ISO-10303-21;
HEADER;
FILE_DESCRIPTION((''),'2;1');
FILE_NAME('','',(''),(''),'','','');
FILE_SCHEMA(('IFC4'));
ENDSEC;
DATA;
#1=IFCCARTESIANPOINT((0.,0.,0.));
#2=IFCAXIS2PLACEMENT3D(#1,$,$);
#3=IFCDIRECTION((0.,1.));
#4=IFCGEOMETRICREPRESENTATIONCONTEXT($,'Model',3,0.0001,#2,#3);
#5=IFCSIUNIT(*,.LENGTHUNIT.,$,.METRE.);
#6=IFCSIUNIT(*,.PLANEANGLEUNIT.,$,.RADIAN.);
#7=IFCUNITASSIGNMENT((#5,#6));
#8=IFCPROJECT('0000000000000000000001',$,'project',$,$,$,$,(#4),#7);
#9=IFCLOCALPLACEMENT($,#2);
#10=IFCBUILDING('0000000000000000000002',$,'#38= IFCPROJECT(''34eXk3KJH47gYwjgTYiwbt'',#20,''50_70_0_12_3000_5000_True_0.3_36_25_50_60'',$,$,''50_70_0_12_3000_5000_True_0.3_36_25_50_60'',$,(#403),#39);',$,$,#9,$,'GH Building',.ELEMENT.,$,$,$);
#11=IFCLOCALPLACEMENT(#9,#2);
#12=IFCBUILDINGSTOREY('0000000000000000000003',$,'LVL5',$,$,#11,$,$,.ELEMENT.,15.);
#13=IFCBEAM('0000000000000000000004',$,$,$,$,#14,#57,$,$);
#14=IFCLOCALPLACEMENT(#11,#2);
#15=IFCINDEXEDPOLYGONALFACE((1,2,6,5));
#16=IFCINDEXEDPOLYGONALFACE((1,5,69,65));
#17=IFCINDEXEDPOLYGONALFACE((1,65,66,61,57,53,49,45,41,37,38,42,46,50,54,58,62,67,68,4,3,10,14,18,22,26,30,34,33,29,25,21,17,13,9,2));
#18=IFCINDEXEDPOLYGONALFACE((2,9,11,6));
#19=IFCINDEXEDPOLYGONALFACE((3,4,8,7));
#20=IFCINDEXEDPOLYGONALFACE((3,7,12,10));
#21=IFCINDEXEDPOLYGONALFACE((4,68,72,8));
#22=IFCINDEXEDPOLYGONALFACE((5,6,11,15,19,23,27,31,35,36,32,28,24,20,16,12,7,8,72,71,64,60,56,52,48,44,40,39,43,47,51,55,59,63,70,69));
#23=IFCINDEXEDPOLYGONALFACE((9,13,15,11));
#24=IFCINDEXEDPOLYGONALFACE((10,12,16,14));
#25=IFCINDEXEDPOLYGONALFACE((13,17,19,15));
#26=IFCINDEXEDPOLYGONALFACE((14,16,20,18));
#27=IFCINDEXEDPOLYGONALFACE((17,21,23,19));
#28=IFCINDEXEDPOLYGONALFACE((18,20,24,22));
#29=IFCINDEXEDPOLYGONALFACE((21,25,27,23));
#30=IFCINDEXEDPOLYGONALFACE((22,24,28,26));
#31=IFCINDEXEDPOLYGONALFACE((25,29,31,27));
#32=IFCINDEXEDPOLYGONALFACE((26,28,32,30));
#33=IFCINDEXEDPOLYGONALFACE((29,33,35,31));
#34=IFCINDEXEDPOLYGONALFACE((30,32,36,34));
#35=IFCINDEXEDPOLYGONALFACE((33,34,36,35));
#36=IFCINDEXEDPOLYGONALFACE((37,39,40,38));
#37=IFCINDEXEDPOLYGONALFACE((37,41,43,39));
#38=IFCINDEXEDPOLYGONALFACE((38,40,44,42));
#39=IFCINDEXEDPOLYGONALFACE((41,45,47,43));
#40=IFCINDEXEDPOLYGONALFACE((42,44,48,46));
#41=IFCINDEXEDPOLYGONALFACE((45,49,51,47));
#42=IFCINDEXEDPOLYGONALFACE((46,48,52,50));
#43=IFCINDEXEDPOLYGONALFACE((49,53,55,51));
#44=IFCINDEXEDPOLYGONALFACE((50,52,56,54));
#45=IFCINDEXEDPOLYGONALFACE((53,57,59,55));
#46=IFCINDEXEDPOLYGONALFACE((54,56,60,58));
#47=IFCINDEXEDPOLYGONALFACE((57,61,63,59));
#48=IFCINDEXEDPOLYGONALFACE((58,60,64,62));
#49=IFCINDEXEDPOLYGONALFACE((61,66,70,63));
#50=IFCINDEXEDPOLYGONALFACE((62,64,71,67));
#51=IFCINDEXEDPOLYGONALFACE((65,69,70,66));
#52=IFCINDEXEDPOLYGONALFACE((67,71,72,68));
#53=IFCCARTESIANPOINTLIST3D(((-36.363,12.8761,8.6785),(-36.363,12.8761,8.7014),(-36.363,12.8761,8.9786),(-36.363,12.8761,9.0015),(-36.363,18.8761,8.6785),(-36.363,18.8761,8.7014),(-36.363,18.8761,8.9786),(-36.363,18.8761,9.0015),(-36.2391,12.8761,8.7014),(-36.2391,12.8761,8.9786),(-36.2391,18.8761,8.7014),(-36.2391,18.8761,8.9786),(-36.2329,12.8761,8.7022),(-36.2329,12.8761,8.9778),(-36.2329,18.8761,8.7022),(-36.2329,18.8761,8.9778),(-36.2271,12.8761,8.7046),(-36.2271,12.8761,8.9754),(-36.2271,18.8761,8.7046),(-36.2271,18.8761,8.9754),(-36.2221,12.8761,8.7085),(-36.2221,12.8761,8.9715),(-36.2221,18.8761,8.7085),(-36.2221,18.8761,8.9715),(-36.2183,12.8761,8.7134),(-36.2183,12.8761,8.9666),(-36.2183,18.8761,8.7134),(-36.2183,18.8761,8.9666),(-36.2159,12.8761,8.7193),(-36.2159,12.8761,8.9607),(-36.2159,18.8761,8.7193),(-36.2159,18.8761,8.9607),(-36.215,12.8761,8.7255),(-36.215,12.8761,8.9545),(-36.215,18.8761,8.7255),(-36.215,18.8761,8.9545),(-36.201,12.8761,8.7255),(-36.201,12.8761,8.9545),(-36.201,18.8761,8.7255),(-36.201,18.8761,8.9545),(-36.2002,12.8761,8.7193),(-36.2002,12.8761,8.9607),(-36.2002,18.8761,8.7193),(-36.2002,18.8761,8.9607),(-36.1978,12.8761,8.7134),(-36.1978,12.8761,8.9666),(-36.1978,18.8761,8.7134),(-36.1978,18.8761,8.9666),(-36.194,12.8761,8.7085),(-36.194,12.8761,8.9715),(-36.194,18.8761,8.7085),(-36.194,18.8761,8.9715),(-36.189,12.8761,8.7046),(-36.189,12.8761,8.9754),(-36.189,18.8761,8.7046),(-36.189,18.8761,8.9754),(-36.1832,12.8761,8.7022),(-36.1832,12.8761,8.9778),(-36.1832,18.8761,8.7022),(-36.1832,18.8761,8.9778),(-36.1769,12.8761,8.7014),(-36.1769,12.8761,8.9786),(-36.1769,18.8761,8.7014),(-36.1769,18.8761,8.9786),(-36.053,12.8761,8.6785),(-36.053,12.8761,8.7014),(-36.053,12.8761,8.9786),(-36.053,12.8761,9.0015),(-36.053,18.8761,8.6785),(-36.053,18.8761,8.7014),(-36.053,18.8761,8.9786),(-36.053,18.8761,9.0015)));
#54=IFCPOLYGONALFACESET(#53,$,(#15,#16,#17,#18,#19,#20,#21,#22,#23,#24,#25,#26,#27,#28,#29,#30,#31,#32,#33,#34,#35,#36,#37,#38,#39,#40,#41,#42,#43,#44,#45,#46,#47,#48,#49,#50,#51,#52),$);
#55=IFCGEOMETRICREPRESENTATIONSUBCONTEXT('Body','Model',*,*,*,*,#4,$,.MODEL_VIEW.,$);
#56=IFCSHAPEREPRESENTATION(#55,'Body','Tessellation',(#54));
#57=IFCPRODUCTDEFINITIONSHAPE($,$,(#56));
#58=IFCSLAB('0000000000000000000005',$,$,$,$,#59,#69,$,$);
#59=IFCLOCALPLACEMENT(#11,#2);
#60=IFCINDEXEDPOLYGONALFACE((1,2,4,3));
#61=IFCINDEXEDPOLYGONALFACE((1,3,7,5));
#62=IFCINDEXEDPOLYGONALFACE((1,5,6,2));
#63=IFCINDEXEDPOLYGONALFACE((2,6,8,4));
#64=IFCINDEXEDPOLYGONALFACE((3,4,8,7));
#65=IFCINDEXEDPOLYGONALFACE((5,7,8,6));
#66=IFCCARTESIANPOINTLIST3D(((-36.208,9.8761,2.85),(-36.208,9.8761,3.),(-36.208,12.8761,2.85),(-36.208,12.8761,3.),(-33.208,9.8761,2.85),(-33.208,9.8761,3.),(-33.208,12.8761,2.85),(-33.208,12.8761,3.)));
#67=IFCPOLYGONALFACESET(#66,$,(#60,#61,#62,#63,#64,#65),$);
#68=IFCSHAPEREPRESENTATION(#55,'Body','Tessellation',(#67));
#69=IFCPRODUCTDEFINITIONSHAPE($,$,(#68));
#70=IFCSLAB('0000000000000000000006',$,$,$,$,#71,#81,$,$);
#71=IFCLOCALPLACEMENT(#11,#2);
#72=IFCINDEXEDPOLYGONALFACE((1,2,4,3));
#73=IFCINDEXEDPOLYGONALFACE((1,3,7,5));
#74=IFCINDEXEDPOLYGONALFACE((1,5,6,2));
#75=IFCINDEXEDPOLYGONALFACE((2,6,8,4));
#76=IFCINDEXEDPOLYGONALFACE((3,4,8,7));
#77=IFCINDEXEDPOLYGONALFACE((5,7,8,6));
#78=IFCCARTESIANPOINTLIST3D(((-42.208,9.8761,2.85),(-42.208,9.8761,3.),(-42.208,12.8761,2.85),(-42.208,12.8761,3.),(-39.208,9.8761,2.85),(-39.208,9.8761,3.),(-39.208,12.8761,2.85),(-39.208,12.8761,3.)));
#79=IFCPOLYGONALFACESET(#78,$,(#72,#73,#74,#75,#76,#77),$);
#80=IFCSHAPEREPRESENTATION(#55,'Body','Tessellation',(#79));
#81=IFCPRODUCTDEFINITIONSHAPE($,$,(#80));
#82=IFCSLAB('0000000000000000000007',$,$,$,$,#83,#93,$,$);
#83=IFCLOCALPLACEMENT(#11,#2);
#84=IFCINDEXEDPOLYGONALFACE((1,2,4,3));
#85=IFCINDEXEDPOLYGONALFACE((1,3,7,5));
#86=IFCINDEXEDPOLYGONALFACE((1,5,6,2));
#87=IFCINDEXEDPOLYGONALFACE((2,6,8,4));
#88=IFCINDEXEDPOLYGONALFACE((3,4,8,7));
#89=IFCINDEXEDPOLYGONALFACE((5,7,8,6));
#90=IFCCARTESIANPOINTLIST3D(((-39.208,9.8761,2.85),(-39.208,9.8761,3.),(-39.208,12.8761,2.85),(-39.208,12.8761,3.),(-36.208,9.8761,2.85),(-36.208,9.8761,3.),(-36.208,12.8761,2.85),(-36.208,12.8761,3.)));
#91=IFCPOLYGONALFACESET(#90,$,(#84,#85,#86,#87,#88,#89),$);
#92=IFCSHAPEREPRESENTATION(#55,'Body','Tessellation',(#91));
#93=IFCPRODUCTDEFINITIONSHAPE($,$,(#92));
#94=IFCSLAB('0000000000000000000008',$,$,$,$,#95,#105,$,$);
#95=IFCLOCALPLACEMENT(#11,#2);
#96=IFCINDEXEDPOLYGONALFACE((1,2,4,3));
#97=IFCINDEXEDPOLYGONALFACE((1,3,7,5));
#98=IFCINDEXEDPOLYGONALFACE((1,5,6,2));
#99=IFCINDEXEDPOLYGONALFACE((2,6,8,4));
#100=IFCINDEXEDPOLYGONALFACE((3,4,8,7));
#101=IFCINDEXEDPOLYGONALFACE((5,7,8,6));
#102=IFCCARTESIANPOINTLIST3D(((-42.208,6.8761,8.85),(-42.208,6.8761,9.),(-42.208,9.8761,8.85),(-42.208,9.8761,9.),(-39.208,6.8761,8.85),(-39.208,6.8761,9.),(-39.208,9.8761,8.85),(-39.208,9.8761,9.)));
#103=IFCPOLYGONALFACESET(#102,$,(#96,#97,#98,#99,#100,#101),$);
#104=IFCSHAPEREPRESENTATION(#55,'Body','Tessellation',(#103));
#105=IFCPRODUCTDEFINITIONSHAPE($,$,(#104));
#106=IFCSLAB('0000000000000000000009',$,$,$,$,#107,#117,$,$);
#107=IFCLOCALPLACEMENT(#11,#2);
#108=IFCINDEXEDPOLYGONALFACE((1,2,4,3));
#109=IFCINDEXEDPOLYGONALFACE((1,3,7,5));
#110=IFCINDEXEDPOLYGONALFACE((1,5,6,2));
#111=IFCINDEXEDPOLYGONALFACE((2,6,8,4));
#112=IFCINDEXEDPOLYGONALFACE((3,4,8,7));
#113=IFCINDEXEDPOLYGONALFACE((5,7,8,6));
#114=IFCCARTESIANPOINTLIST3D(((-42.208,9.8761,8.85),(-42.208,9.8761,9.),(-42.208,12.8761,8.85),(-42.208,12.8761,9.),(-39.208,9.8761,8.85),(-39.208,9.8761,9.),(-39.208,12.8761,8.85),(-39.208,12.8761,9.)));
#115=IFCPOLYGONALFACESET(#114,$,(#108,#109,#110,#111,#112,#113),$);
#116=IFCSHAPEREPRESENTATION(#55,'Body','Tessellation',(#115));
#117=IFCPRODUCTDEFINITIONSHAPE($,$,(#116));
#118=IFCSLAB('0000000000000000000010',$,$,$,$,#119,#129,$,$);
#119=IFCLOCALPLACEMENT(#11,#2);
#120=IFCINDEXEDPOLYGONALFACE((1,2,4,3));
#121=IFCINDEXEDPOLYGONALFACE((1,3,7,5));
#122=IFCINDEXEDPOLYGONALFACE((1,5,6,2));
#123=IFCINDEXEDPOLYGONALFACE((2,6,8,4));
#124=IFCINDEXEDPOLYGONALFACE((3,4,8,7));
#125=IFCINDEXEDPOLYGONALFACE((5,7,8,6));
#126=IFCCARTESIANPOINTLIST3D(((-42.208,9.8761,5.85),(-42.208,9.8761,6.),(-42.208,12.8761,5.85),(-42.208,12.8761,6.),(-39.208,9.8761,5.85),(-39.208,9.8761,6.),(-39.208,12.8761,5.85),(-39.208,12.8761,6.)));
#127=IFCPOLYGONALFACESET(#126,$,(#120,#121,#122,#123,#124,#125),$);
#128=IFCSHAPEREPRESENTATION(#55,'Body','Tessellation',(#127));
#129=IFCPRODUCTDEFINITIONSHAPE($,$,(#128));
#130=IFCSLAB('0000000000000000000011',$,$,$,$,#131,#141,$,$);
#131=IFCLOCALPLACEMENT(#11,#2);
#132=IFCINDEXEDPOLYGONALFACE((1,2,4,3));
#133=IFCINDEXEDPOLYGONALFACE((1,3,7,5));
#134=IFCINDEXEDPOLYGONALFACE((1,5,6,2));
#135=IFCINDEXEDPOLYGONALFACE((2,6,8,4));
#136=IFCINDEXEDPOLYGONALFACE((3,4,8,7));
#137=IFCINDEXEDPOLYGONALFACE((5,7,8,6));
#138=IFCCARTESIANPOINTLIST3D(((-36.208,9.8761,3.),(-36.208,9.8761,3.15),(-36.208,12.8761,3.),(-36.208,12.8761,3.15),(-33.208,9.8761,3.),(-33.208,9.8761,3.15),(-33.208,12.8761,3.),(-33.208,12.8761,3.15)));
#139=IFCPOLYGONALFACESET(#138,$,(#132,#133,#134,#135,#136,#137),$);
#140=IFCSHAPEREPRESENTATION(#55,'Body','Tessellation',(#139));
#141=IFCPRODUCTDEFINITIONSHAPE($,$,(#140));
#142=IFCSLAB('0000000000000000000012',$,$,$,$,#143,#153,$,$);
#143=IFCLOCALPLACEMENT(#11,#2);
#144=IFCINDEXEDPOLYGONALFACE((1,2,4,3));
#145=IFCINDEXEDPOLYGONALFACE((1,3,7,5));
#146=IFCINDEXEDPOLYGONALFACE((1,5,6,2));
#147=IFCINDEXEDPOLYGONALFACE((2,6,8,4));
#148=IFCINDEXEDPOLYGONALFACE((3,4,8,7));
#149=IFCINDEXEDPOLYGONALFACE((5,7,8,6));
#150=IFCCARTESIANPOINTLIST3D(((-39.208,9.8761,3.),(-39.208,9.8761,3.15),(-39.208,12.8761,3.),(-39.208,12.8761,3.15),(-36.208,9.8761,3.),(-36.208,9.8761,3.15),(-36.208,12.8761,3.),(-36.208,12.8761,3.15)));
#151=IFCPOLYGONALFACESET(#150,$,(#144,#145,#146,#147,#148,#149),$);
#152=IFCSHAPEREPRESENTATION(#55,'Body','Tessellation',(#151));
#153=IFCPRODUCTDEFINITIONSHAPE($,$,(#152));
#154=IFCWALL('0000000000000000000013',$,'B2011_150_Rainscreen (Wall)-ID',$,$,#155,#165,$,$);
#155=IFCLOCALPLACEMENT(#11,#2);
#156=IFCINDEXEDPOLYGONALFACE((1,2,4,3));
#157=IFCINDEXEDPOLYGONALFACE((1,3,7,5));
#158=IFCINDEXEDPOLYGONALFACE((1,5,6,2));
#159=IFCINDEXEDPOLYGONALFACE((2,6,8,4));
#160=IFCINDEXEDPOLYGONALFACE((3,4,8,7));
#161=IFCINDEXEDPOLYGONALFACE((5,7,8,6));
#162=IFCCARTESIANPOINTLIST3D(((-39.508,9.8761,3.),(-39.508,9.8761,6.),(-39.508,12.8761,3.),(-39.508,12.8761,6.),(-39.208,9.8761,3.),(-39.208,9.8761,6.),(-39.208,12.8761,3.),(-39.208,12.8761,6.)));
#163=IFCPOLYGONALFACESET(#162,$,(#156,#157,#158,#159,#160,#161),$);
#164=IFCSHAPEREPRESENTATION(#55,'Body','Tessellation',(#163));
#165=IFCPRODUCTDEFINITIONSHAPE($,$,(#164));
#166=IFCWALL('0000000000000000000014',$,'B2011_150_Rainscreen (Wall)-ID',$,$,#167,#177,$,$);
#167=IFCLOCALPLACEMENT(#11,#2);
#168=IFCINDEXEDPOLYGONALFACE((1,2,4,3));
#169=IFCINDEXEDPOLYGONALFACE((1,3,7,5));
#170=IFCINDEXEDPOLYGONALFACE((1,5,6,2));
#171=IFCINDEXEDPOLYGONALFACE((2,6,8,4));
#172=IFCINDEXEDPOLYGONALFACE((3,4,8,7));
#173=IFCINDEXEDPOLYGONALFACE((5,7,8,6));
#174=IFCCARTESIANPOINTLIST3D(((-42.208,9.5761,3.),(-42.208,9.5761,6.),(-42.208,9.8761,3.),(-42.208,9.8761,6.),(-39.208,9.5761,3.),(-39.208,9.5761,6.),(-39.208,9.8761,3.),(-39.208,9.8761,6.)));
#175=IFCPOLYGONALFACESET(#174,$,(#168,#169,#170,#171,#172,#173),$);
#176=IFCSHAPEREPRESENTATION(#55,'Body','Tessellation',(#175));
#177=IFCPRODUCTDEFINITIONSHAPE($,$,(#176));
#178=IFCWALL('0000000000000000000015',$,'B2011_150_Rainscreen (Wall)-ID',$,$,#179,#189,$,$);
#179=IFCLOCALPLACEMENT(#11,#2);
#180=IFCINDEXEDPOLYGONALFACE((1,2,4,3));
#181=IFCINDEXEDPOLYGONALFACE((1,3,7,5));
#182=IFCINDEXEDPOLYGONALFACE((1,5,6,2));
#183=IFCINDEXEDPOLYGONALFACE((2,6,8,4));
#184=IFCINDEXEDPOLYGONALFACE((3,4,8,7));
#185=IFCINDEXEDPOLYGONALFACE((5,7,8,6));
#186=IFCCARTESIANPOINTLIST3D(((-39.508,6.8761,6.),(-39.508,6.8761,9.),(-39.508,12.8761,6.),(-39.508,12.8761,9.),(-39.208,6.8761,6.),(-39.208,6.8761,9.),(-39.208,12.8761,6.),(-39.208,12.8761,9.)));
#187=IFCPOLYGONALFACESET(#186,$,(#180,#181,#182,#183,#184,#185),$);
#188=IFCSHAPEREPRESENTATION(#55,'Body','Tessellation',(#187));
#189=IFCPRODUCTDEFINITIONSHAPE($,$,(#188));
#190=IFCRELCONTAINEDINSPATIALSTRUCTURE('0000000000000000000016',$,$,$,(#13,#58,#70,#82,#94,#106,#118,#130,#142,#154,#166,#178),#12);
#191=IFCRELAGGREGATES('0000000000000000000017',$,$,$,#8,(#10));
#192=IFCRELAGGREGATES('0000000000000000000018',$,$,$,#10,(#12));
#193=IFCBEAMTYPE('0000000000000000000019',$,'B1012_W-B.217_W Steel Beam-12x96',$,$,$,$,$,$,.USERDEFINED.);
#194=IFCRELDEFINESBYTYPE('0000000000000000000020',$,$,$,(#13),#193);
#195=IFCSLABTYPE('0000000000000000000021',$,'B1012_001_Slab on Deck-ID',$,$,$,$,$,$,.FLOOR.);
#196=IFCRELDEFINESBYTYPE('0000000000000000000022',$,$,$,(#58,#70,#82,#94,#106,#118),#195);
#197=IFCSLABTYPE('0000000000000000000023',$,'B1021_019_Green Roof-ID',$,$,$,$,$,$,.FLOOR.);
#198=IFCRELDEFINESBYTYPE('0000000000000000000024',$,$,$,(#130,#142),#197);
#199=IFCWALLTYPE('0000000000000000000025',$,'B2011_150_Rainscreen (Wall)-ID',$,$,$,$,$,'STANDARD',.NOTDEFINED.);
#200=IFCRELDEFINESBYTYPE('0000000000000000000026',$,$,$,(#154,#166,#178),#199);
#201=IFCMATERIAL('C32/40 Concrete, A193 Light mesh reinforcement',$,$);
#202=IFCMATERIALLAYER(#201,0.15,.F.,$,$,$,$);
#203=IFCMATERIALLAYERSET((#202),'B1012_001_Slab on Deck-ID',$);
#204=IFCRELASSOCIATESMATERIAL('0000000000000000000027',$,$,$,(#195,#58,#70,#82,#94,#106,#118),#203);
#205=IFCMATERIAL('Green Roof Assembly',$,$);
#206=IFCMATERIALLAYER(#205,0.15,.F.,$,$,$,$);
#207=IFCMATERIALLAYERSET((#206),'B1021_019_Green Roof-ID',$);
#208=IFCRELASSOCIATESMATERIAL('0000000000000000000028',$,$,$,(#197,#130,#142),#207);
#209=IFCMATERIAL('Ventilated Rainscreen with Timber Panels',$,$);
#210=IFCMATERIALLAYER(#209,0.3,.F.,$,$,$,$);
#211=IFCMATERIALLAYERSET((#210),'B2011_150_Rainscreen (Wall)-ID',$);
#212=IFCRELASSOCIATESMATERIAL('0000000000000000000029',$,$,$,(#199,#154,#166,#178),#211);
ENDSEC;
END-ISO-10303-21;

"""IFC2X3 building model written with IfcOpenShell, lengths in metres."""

from ifc_helpers import new_model, si_unit, direction, frame, frame_2d, origin, origin_2d, place, context, subcontext, project, spatial, polyline, rectangle, i_section, outline, extrude, material, layer, layer_set, layer_usage, type_object, element, save


model = new_model("IFC2X3")

# Units and contexts
model_context = context("Model", 3, precision=0.0001, world=origin(), true_north=direction((0.0, 1.0)))
body_context = subcontext(model_context, "Body", "Model", "MODEL_VIEW")
ifc_project = project(units=[si_unit("LENGTHUNIT", "METRE"), si_unit("PLANEANGLEUNIT", "RADIAN")], contexts=[model_context])

# Building, storey
building_placement = place(None, origin())
building = spatial("IfcBuilding", under=ifc_project, at=building_placement, Name="#38= IFCPROJECT('34eXk3KJH47gYwjgTYiwbt',#20,'50_70_0_12_3000_5000_True_0.3_36_25_50_60',$,$,'50_70_0_12_3000_5000_True_0.3_36_25_50_60',$,(#403),#39);", LongName="GH Building", CompositionType="ELEMENT")
storey_placement = place(building_placement, origin())
storey = spatial("IfcBuildingStorey", under=building, at=storey_placement, Name="LVL5", CompositionType="ELEMENT", Elevation=15.0)

# Beam
beam_type = type_object("IfcBeamType", Name="B1012_W-B.217_W Steel Beam-12x96", PredefinedType="USERDEFINED")
for number, where, z_axis, x_axis in (
    (1, (-36.208, 12.8761, 8.84), (0.0, 1.0, 0.0), (-1.0, 0.0, 0.0)),
):
    element("IfcBeam", number, at=place(storey_placement, frame(where, z_axis=z_axis, x_axis=x_axis)), inside=storey, type_object=beam_type, context=body_context, shape_type="SweptSolid", body=[
        extrude(i_section(OverallWidth=0.31, OverallDepth=0.323, WebThickness=0.014, FlangeThickness=0.0229, FilletRadius=0.0241, at=origin_2d()), origin(), (0.0, 0.0, 1.0), 6.0),
    ])

# Slabs
ifc_material_1 = material(Name="C32/40 Concrete, A193 Light mesh reinforcement")
ifc_layer_1 = layer(ifc_material_1, 0.15, ventilated=False)
ifc_layer_set_1 = layer_set([ifc_layer_1], Name="B1012_001_Slab on Deck-ID")
ifc_layer_usage_1 = layer_usage(ifc_layer_set_1, "AXIS3", "NEGATIVE", -0.15)
slab_type_1 = type_object("IfcSlabType", Name="B1012_001_Slab on Deck-ID", PredefinedType="FLOOR", material=ifc_layer_set_1)
slab_1_placement = place(storey_placement, frame((-34.708, 11.3761, 2.85), z_axis=(0.0, 0.0, 1.0), x_axis=(0.0, 1.0, 0.0)))
element("IfcSlab", 2, at=slab_1_placement, inside=storey, type_object=slab_type_1, material=ifc_layer_usage_1, context=body_context, shape_type="SweptSolid", body=[
    extrude(outline(polyline([(-1.5, -1.5), (1.5, -1.5), (1.5, 1.5), (-1.5, 1.5), (-1.5, -1.5)])), origin(), (0.0, 0.0, 1.0), 0.15),
])
ifc_layer_usage_2 = layer_usage(ifc_layer_set_1, "AXIS3", "NEGATIVE", -0.15)
slab_2_placement = place(storey_placement, frame((-40.708, 11.3761, 2.85)))
element("IfcSlab", 3, at=slab_2_placement, inside=storey, type_object=slab_type_1, material=ifc_layer_usage_2, context=body_context, shape_type="SweptSolid", body=[
    extrude(outline(polyline([(-1.5, -1.5), (1.5, -1.5), (1.5, 1.5), (-1.5, 1.5), (-1.5, -1.5)])), origin(), (0.0, 0.0, 1.0), 0.15),
])
ifc_layer_usage_3 = layer_usage(ifc_layer_set_1, "AXIS3", "NEGATIVE", -0.15)
slab_3_placement = place(storey_placement, frame((-37.708, 11.3761, 2.85)))
element("IfcSlab", 4, at=slab_3_placement, inside=storey, type_object=slab_type_1, material=ifc_layer_usage_3, context=body_context, shape_type="SweptSolid", body=[
    extrude(outline(polyline([(-1.5, -1.5), (1.5, -1.5), (1.5, 1.5), (-1.5, 1.5), (-1.5, -1.5)])), origin(), (0.0, 0.0, 1.0), 0.15),
])
ifc_layer_usage_4 = layer_usage(ifc_layer_set_1, "AXIS3", "NEGATIVE", -0.15)
slab_4_placement = place(storey_placement, frame((-40.708, 8.3761, 8.85)))
element("IfcSlab", 5, at=slab_4_placement, inside=storey, type_object=slab_type_1, material=ifc_layer_usage_4, context=body_context, shape_type="SweptSolid", body=[
    extrude(outline(polyline([(1.5, 1.5), (1.5, -1.5), (-1.5, -1.5), (-1.5, 1.5), (1.5, 1.5)])), origin(), (0.0, 0.0, 1.0), 0.15),
])
ifc_layer_usage_5 = layer_usage(ifc_layer_set_1, "AXIS3", "NEGATIVE", -0.15)
slab_5_placement = place(storey_placement, frame((-40.708, 11.3761, 8.85)))
element("IfcSlab", 6, at=slab_5_placement, inside=storey, type_object=slab_type_1, material=ifc_layer_usage_5, context=body_context, shape_type="SweptSolid", body=[
    extrude(outline(polyline([(-1.5, -1.5), (-1.5, 1.5), (1.5, 1.5), (1.5, -1.5), (-1.5, -1.5)])), origin(), (0.0, 0.0, 1.0), 0.15),
])
ifc_layer_usage_6 = layer_usage(ifc_layer_set_1, "AXIS3", "NEGATIVE", -0.15)
slab_6_placement = place(storey_placement, frame((-40.708, 11.3761, 5.85)))
element("IfcSlab", 7, at=slab_6_placement, inside=storey, type_object=slab_type_1, material=ifc_layer_usage_6, context=body_context, shape_type="SweptSolid", body=[
    extrude(outline(polyline([(-1.5, -1.5), (-1.5, 1.5), (1.5, 1.5), (1.5, -1.5), (-1.5, -1.5)])), origin(), (0.0, 0.0, 1.0), 0.15),
])
ifc_material_2 = material(Name="Green Roof Assembly")
ifc_layer_2 = layer(ifc_material_2, 0.15, ventilated=False)
ifc_layer_set_2 = layer_set([ifc_layer_2], Name="B1021_019_Green Roof-ID")
ifc_layer_usage_7 = layer_usage(ifc_layer_set_2, "AXIS3", "NEGATIVE", -0.15)
slab_type_2 = type_object("IfcSlabType", Name="B1021_019_Green Roof-ID", PredefinedType="FLOOR", material=ifc_layer_set_2)
slab_7_placement = place(storey_placement, frame((-34.708, 11.3761, 3.0), z_axis=(0.0, 0.0, 1.0), x_axis=(0.0, 1.0, 0.0)))
element("IfcSlab", 8, at=slab_7_placement, inside=storey, type_object=slab_type_2, material=ifc_layer_usage_7, context=body_context, shape_type="SweptSolid", body=[
    extrude(outline(polyline([(-1.5, -1.5), (1.5, -1.5), (1.5, 1.5), (-1.5, 1.5), (-1.5, -1.5)])), origin(), (0.0, 0.0, 1.0), 0.15),
])
ifc_layer_usage_8 = layer_usage(ifc_layer_set_2, "AXIS3", "NEGATIVE", -0.15)
slab_8_placement = place(storey_placement, frame((-37.708, 11.3761, 3.0)))
element("IfcSlab", 9, at=slab_8_placement, inside=storey, type_object=slab_type_2, material=ifc_layer_usage_8, context=body_context, shape_type="SweptSolid", body=[
    extrude(outline(polyline([(-1.5, -1.5), (1.5, -1.5), (1.5, 1.5), (-1.5, 1.5), (-1.5, -1.5)])), origin(), (0.0, 0.0, 1.0), 0.15),
])

# Walls
ifc_material_3 = material(Name="Ventilated Rainscreen with Timber Panels")
ifc_layer_3 = layer(ifc_material_3, 0.3, ventilated=False)
ifc_layer_set_3 = layer_set([ifc_layer_3], Name="B2011_150_Rainscreen (Wall)-ID")
ifc_layer_usage_9 = layer_usage(ifc_layer_set_3, "AXIS2", "POSITIVE", 0.0)
wall_type = type_object("IfcWallType", Name="B2011_150_Rainscreen (Wall)-ID", ElementType="STANDARD", PredefinedType="NOTDEFINED", material=ifc_layer_set_3)
wall_1_placement = place(storey_placement, frame((-39.208, 9.8761, 3.0), z_axis=(0.0, 0.0, 1.0), x_axis=(0.0, 1.0, 0.0)))
element("IfcWall", 10, at=wall_1_placement, inside=storey, type_object=wall_type, material=ifc_layer_usage_9, Name="B2011_150_Rainscreen (Wall)-ID", context=body_context, shape_type="SweptSolid", body=[
    extrude(rectangle(XDim=3.0, YDim=0.3, at=frame_2d((1.5, 0.15))), origin(), (0.0, 0.0, 1.0), 3.0),
])
ifc_layer_usage_10 = layer_usage(ifc_layer_set_3, "AXIS2", "POSITIVE", 0.0)
wall_2_placement = place(storey_placement, frame((-39.208, 9.8761, 3.0), z_axis=(0.0, 0.0, 1.0), x_axis=(-1.0, 0.0, 0.0)))
element("IfcWall", 11, at=wall_2_placement, inside=storey, type_object=wall_type, material=ifc_layer_usage_10, Name="B2011_150_Rainscreen (Wall)-ID", context=body_context, shape_type="SweptSolid", body=[
    extrude(rectangle(XDim=3.0, YDim=0.3, at=frame_2d((1.5, 0.15))), origin(), (0.0, 0.0, 1.0), 3.0),
])
ifc_layer_usage_11 = layer_usage(ifc_layer_set_3, "AXIS2", "POSITIVE", 0.0)
wall_3_placement = place(storey_placement, frame((-39.208, 6.8761, 6.0), z_axis=(0.0, 0.0, 1.0), x_axis=(0.0, 1.0, 0.0)))
element("IfcWall", 12, at=wall_3_placement, inside=storey, type_object=wall_type, material=ifc_layer_usage_11, Name="B2011_150_Rainscreen (Wall)-ID", context=body_context, shape_type="SweptSolid", body=[
    extrude(rectangle(XDim=6.0, YDim=0.3, at=frame_2d((3.0, 0.15))), origin(), (0.0, 0.0, 1.0), 3.0),
])

save(model, "model.ifc")
